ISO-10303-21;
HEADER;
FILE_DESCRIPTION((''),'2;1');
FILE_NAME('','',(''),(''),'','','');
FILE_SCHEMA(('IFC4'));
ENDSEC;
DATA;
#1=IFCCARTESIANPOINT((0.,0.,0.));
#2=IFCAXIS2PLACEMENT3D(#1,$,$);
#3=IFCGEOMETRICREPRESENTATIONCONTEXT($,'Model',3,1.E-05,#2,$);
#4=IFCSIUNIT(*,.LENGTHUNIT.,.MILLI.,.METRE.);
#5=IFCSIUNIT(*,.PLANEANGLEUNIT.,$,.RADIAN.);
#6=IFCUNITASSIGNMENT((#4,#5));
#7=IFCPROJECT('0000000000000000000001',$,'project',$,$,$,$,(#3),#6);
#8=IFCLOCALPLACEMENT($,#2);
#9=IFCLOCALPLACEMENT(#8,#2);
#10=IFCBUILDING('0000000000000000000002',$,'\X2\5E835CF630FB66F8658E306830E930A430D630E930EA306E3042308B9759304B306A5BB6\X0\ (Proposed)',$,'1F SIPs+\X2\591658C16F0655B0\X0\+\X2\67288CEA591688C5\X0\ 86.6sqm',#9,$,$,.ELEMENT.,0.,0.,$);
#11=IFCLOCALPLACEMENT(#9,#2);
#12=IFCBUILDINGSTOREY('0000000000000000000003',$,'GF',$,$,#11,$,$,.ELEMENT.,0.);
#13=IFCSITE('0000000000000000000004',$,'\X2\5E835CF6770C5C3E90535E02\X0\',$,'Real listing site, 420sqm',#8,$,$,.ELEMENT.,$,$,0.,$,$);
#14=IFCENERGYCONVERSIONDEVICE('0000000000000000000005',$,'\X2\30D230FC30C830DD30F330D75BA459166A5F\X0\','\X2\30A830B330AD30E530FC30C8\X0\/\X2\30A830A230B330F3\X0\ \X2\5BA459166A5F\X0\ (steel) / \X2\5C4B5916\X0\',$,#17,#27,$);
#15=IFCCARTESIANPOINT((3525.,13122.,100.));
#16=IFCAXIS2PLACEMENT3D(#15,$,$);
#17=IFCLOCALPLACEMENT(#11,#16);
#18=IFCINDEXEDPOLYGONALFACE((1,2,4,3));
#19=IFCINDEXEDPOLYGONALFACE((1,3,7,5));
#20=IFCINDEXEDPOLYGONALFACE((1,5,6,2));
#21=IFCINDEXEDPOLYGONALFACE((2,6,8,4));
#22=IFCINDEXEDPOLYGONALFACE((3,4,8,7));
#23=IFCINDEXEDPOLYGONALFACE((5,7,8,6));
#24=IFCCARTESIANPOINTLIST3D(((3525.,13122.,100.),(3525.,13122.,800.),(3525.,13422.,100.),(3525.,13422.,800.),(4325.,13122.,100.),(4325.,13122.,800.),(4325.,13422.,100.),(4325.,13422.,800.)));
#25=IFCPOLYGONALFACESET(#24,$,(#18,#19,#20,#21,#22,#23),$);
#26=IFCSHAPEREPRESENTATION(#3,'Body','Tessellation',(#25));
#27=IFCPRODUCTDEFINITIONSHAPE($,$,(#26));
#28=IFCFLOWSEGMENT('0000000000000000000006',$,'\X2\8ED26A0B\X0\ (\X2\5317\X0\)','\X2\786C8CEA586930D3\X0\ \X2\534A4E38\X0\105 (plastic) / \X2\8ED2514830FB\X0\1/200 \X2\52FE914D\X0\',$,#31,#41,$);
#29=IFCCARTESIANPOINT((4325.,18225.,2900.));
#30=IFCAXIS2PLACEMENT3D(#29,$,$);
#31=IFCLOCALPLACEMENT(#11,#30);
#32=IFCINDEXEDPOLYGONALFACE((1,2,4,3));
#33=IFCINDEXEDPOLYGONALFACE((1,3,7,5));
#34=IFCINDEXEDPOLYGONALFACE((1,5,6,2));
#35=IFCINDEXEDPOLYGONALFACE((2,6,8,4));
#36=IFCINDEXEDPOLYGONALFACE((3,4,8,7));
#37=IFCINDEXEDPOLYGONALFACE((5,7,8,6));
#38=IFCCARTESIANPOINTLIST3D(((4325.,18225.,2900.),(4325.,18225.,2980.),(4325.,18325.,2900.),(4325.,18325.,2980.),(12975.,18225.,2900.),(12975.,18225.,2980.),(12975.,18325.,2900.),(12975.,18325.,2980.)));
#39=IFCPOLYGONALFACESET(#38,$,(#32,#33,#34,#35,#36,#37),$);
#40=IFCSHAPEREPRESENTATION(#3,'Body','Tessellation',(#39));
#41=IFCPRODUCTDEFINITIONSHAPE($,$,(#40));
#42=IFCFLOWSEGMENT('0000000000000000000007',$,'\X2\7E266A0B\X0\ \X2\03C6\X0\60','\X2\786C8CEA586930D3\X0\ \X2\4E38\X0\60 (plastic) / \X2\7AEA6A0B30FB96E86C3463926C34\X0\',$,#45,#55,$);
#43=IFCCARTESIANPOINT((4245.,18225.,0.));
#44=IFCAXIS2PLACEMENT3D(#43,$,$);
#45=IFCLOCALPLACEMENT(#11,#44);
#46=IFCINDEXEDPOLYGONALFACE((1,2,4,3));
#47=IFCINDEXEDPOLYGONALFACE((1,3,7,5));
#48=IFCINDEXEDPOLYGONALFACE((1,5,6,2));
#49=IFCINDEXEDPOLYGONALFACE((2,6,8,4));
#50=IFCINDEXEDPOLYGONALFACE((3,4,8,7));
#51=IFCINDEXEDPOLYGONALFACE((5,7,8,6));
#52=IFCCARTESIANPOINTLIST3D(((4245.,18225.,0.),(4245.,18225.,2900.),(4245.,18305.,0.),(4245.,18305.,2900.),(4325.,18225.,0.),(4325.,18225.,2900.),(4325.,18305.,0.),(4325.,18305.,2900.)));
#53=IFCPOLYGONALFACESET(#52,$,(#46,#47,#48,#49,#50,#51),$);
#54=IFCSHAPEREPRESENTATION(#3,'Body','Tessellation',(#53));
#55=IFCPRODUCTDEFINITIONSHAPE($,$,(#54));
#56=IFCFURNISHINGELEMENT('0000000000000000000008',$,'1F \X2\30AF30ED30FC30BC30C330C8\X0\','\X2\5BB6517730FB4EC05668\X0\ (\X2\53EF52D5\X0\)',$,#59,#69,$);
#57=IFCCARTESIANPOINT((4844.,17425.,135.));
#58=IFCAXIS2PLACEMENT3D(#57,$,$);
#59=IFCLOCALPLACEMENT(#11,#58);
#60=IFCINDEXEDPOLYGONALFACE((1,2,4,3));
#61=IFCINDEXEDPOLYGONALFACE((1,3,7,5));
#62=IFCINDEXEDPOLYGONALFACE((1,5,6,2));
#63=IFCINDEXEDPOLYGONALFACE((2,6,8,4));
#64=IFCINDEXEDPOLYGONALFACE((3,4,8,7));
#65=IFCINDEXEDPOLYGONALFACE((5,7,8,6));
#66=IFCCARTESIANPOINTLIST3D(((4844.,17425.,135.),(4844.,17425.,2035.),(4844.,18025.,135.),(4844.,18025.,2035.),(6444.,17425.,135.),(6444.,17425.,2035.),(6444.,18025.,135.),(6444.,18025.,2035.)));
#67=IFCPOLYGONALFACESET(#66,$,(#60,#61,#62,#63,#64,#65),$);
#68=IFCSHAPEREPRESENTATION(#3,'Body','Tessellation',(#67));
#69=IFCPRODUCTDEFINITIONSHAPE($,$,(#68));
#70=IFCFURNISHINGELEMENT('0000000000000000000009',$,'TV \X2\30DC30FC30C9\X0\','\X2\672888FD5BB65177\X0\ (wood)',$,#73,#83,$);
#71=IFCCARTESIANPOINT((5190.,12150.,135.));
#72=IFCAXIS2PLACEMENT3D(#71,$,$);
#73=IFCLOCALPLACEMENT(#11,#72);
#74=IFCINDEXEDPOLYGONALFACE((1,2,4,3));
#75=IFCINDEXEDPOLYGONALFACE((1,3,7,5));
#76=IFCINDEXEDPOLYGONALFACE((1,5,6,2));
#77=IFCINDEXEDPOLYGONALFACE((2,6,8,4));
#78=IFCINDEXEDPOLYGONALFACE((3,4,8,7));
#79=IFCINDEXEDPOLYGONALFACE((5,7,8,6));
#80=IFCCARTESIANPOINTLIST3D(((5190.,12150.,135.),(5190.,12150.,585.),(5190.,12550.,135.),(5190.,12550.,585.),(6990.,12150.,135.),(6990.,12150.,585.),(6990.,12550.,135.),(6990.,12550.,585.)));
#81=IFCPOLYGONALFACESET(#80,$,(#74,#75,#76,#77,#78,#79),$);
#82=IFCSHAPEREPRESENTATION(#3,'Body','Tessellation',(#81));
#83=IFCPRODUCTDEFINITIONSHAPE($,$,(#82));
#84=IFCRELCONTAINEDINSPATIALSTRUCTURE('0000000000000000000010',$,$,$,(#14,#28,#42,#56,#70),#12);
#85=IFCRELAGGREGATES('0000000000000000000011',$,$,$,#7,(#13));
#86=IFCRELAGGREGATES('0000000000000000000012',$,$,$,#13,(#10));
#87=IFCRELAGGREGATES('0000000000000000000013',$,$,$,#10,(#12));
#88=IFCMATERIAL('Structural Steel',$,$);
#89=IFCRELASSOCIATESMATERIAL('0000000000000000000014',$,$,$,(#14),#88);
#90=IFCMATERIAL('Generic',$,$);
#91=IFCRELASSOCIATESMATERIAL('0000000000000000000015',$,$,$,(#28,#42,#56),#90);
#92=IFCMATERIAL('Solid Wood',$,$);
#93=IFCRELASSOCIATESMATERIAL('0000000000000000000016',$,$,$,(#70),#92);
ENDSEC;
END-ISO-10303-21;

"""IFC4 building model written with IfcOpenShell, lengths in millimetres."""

from ifc_helpers import new_model, si_unit, frame, frame_2d, origin, place, context, project, spatial, rectangle, extrude, material, element, save


model = new_model("IFC4")

# Units and contexts
model_context = context("Model", 3, precision=1e-05, world=origin())
ifc_project = project(units=[si_unit("LENGTHUNIT", "METRE", prefix="MILLI"), si_unit("PLANEANGLEUNIT", "RADIAN")], contexts=[model_context])

# Site, building, storey
site_placement = place(None, origin())
site = spatial("IfcSite", under=ifc_project, at=site_placement, Name="広島県尾道市", ObjectType="Real listing site, 420sqm", CompositionType="ELEMENT", RefElevation=0.0)
building_placement = place(site_placement, origin())
building = spatial("IfcBuilding", under=site, at=building_placement, Name="広島・書斎とライブラリのある静かな家 (Proposed)", ObjectType="1F SIPs+外壁漆喰+木質外装 86.6sqm", CompositionType="ELEMENT", ElevationOfRefHeight=0.0, ElevationOfTerrain=0.0)
storey_placement = place(building_placement, origin())
storey = spatial("IfcBuildingStorey", under=building, at=storey_placement, Name="GF", CompositionType="ELEMENT", Elevation=0.0)

# Shared definitions
ifc_material_1 = material(Name="Solid Wood")

# Shared definitions
ifc_material_2 = material(Name="Structural Steel")

# Shared definitions
ifc_material_3 = material(Name="Generic")

# Energy conversion device
energy_conversion_device_placement = place(storey_placement, frame((3525.0, 13122.0, 100.0)))
element("IfcEnergyConversionDevice", 1, at=energy_conversion_device_placement, inside=storey, material=ifc_material_2, Name="ヒートポンプ室外機", Description="エコキュート/エアコン 室外機 (steel) / 屋外", context=model_context, shape_type="SweptSolid", body=[
    extrude(rectangle(XDim=800.0, YDim=300.0, at=frame_2d((400.0, 150.0))), frame((3525.0, 13122.0, 100.0)), (0.0, 0.0, 1.0), 700.0),
])

# Flow segments
flow_segment_1_placement = place(storey_placement, frame((4325.0, 18225.0, 2900.0)))
element("IfcFlowSegment", 2, at=flow_segment_1_placement, inside=storey, material=ifc_material_3, Name="軒樋 (北)", Description="硬質塩ビ 半丸105 (plastic) / 軒先・1/200 勾配", context=model_context, shape_type="SweptSolid", body=[
    extrude(rectangle(XDim=8650.0, YDim=100.0, at=frame_2d((4325.0, 50.0))), frame((4325.0, 18225.0, 2900.0)), (0.0, 0.0, 1.0), 80.0),
])
flow_segment_2_placement = place(storey_placement, frame((4245.0, 18225.0, 0.0)))
element("IfcFlowSegment", 3, at=flow_segment_2_placement, inside=storey, material=ifc_material_3, Name="縦樋 φ60", Description="硬質塩ビ 丸60 (plastic) / 竪樋・雨水排水", context=model_context, shape_type="SweptSolid", body=[
    extrude(rectangle(XDim=80.0, YDim=80.0, at=frame_2d((40.0, 40.0))), frame((4245.0, 18225.0, 0.0)), (0.0, 0.0, 1.0), 2900.0),
])

# Furnishing elements
furnishing_1_placement = place(storey_placement, frame((4844.0, 17425.0, 135.0)))
element("IfcFurnishingElement", 4, at=furnishing_1_placement, inside=storey, material=ifc_material_3, Name="1F クローゼット", Description="家具・什器 (可動)", context=model_context, shape_type="SweptSolid", body=[
    extrude(rectangle(XDim=1600.0, YDim=600.0, at=frame_2d((800.0, 300.0))), frame((4844.0, 17425.0, 135.0)), (0.0, 0.0, 1.0), 1900.0),
])
furnishing_2_placement = place(storey_placement, frame((5190.0, 12150.0, 135.0)))
element("IfcFurnishingElement", 5, at=furnishing_2_placement, inside=storey, material=ifc_material_1, Name="TV ボード", Description="木製家具 (wood)", context=model_context, shape_type="SweptSolid", body=[
    extrude(rectangle(XDim=1800.0, YDim=400.0, at=frame_2d((900.0, 200.0))), frame((5190.0, 12150.0, 135.0)), (0.0, 0.0, 1.0), 450.0),
])

save(model, "model.ifc")
